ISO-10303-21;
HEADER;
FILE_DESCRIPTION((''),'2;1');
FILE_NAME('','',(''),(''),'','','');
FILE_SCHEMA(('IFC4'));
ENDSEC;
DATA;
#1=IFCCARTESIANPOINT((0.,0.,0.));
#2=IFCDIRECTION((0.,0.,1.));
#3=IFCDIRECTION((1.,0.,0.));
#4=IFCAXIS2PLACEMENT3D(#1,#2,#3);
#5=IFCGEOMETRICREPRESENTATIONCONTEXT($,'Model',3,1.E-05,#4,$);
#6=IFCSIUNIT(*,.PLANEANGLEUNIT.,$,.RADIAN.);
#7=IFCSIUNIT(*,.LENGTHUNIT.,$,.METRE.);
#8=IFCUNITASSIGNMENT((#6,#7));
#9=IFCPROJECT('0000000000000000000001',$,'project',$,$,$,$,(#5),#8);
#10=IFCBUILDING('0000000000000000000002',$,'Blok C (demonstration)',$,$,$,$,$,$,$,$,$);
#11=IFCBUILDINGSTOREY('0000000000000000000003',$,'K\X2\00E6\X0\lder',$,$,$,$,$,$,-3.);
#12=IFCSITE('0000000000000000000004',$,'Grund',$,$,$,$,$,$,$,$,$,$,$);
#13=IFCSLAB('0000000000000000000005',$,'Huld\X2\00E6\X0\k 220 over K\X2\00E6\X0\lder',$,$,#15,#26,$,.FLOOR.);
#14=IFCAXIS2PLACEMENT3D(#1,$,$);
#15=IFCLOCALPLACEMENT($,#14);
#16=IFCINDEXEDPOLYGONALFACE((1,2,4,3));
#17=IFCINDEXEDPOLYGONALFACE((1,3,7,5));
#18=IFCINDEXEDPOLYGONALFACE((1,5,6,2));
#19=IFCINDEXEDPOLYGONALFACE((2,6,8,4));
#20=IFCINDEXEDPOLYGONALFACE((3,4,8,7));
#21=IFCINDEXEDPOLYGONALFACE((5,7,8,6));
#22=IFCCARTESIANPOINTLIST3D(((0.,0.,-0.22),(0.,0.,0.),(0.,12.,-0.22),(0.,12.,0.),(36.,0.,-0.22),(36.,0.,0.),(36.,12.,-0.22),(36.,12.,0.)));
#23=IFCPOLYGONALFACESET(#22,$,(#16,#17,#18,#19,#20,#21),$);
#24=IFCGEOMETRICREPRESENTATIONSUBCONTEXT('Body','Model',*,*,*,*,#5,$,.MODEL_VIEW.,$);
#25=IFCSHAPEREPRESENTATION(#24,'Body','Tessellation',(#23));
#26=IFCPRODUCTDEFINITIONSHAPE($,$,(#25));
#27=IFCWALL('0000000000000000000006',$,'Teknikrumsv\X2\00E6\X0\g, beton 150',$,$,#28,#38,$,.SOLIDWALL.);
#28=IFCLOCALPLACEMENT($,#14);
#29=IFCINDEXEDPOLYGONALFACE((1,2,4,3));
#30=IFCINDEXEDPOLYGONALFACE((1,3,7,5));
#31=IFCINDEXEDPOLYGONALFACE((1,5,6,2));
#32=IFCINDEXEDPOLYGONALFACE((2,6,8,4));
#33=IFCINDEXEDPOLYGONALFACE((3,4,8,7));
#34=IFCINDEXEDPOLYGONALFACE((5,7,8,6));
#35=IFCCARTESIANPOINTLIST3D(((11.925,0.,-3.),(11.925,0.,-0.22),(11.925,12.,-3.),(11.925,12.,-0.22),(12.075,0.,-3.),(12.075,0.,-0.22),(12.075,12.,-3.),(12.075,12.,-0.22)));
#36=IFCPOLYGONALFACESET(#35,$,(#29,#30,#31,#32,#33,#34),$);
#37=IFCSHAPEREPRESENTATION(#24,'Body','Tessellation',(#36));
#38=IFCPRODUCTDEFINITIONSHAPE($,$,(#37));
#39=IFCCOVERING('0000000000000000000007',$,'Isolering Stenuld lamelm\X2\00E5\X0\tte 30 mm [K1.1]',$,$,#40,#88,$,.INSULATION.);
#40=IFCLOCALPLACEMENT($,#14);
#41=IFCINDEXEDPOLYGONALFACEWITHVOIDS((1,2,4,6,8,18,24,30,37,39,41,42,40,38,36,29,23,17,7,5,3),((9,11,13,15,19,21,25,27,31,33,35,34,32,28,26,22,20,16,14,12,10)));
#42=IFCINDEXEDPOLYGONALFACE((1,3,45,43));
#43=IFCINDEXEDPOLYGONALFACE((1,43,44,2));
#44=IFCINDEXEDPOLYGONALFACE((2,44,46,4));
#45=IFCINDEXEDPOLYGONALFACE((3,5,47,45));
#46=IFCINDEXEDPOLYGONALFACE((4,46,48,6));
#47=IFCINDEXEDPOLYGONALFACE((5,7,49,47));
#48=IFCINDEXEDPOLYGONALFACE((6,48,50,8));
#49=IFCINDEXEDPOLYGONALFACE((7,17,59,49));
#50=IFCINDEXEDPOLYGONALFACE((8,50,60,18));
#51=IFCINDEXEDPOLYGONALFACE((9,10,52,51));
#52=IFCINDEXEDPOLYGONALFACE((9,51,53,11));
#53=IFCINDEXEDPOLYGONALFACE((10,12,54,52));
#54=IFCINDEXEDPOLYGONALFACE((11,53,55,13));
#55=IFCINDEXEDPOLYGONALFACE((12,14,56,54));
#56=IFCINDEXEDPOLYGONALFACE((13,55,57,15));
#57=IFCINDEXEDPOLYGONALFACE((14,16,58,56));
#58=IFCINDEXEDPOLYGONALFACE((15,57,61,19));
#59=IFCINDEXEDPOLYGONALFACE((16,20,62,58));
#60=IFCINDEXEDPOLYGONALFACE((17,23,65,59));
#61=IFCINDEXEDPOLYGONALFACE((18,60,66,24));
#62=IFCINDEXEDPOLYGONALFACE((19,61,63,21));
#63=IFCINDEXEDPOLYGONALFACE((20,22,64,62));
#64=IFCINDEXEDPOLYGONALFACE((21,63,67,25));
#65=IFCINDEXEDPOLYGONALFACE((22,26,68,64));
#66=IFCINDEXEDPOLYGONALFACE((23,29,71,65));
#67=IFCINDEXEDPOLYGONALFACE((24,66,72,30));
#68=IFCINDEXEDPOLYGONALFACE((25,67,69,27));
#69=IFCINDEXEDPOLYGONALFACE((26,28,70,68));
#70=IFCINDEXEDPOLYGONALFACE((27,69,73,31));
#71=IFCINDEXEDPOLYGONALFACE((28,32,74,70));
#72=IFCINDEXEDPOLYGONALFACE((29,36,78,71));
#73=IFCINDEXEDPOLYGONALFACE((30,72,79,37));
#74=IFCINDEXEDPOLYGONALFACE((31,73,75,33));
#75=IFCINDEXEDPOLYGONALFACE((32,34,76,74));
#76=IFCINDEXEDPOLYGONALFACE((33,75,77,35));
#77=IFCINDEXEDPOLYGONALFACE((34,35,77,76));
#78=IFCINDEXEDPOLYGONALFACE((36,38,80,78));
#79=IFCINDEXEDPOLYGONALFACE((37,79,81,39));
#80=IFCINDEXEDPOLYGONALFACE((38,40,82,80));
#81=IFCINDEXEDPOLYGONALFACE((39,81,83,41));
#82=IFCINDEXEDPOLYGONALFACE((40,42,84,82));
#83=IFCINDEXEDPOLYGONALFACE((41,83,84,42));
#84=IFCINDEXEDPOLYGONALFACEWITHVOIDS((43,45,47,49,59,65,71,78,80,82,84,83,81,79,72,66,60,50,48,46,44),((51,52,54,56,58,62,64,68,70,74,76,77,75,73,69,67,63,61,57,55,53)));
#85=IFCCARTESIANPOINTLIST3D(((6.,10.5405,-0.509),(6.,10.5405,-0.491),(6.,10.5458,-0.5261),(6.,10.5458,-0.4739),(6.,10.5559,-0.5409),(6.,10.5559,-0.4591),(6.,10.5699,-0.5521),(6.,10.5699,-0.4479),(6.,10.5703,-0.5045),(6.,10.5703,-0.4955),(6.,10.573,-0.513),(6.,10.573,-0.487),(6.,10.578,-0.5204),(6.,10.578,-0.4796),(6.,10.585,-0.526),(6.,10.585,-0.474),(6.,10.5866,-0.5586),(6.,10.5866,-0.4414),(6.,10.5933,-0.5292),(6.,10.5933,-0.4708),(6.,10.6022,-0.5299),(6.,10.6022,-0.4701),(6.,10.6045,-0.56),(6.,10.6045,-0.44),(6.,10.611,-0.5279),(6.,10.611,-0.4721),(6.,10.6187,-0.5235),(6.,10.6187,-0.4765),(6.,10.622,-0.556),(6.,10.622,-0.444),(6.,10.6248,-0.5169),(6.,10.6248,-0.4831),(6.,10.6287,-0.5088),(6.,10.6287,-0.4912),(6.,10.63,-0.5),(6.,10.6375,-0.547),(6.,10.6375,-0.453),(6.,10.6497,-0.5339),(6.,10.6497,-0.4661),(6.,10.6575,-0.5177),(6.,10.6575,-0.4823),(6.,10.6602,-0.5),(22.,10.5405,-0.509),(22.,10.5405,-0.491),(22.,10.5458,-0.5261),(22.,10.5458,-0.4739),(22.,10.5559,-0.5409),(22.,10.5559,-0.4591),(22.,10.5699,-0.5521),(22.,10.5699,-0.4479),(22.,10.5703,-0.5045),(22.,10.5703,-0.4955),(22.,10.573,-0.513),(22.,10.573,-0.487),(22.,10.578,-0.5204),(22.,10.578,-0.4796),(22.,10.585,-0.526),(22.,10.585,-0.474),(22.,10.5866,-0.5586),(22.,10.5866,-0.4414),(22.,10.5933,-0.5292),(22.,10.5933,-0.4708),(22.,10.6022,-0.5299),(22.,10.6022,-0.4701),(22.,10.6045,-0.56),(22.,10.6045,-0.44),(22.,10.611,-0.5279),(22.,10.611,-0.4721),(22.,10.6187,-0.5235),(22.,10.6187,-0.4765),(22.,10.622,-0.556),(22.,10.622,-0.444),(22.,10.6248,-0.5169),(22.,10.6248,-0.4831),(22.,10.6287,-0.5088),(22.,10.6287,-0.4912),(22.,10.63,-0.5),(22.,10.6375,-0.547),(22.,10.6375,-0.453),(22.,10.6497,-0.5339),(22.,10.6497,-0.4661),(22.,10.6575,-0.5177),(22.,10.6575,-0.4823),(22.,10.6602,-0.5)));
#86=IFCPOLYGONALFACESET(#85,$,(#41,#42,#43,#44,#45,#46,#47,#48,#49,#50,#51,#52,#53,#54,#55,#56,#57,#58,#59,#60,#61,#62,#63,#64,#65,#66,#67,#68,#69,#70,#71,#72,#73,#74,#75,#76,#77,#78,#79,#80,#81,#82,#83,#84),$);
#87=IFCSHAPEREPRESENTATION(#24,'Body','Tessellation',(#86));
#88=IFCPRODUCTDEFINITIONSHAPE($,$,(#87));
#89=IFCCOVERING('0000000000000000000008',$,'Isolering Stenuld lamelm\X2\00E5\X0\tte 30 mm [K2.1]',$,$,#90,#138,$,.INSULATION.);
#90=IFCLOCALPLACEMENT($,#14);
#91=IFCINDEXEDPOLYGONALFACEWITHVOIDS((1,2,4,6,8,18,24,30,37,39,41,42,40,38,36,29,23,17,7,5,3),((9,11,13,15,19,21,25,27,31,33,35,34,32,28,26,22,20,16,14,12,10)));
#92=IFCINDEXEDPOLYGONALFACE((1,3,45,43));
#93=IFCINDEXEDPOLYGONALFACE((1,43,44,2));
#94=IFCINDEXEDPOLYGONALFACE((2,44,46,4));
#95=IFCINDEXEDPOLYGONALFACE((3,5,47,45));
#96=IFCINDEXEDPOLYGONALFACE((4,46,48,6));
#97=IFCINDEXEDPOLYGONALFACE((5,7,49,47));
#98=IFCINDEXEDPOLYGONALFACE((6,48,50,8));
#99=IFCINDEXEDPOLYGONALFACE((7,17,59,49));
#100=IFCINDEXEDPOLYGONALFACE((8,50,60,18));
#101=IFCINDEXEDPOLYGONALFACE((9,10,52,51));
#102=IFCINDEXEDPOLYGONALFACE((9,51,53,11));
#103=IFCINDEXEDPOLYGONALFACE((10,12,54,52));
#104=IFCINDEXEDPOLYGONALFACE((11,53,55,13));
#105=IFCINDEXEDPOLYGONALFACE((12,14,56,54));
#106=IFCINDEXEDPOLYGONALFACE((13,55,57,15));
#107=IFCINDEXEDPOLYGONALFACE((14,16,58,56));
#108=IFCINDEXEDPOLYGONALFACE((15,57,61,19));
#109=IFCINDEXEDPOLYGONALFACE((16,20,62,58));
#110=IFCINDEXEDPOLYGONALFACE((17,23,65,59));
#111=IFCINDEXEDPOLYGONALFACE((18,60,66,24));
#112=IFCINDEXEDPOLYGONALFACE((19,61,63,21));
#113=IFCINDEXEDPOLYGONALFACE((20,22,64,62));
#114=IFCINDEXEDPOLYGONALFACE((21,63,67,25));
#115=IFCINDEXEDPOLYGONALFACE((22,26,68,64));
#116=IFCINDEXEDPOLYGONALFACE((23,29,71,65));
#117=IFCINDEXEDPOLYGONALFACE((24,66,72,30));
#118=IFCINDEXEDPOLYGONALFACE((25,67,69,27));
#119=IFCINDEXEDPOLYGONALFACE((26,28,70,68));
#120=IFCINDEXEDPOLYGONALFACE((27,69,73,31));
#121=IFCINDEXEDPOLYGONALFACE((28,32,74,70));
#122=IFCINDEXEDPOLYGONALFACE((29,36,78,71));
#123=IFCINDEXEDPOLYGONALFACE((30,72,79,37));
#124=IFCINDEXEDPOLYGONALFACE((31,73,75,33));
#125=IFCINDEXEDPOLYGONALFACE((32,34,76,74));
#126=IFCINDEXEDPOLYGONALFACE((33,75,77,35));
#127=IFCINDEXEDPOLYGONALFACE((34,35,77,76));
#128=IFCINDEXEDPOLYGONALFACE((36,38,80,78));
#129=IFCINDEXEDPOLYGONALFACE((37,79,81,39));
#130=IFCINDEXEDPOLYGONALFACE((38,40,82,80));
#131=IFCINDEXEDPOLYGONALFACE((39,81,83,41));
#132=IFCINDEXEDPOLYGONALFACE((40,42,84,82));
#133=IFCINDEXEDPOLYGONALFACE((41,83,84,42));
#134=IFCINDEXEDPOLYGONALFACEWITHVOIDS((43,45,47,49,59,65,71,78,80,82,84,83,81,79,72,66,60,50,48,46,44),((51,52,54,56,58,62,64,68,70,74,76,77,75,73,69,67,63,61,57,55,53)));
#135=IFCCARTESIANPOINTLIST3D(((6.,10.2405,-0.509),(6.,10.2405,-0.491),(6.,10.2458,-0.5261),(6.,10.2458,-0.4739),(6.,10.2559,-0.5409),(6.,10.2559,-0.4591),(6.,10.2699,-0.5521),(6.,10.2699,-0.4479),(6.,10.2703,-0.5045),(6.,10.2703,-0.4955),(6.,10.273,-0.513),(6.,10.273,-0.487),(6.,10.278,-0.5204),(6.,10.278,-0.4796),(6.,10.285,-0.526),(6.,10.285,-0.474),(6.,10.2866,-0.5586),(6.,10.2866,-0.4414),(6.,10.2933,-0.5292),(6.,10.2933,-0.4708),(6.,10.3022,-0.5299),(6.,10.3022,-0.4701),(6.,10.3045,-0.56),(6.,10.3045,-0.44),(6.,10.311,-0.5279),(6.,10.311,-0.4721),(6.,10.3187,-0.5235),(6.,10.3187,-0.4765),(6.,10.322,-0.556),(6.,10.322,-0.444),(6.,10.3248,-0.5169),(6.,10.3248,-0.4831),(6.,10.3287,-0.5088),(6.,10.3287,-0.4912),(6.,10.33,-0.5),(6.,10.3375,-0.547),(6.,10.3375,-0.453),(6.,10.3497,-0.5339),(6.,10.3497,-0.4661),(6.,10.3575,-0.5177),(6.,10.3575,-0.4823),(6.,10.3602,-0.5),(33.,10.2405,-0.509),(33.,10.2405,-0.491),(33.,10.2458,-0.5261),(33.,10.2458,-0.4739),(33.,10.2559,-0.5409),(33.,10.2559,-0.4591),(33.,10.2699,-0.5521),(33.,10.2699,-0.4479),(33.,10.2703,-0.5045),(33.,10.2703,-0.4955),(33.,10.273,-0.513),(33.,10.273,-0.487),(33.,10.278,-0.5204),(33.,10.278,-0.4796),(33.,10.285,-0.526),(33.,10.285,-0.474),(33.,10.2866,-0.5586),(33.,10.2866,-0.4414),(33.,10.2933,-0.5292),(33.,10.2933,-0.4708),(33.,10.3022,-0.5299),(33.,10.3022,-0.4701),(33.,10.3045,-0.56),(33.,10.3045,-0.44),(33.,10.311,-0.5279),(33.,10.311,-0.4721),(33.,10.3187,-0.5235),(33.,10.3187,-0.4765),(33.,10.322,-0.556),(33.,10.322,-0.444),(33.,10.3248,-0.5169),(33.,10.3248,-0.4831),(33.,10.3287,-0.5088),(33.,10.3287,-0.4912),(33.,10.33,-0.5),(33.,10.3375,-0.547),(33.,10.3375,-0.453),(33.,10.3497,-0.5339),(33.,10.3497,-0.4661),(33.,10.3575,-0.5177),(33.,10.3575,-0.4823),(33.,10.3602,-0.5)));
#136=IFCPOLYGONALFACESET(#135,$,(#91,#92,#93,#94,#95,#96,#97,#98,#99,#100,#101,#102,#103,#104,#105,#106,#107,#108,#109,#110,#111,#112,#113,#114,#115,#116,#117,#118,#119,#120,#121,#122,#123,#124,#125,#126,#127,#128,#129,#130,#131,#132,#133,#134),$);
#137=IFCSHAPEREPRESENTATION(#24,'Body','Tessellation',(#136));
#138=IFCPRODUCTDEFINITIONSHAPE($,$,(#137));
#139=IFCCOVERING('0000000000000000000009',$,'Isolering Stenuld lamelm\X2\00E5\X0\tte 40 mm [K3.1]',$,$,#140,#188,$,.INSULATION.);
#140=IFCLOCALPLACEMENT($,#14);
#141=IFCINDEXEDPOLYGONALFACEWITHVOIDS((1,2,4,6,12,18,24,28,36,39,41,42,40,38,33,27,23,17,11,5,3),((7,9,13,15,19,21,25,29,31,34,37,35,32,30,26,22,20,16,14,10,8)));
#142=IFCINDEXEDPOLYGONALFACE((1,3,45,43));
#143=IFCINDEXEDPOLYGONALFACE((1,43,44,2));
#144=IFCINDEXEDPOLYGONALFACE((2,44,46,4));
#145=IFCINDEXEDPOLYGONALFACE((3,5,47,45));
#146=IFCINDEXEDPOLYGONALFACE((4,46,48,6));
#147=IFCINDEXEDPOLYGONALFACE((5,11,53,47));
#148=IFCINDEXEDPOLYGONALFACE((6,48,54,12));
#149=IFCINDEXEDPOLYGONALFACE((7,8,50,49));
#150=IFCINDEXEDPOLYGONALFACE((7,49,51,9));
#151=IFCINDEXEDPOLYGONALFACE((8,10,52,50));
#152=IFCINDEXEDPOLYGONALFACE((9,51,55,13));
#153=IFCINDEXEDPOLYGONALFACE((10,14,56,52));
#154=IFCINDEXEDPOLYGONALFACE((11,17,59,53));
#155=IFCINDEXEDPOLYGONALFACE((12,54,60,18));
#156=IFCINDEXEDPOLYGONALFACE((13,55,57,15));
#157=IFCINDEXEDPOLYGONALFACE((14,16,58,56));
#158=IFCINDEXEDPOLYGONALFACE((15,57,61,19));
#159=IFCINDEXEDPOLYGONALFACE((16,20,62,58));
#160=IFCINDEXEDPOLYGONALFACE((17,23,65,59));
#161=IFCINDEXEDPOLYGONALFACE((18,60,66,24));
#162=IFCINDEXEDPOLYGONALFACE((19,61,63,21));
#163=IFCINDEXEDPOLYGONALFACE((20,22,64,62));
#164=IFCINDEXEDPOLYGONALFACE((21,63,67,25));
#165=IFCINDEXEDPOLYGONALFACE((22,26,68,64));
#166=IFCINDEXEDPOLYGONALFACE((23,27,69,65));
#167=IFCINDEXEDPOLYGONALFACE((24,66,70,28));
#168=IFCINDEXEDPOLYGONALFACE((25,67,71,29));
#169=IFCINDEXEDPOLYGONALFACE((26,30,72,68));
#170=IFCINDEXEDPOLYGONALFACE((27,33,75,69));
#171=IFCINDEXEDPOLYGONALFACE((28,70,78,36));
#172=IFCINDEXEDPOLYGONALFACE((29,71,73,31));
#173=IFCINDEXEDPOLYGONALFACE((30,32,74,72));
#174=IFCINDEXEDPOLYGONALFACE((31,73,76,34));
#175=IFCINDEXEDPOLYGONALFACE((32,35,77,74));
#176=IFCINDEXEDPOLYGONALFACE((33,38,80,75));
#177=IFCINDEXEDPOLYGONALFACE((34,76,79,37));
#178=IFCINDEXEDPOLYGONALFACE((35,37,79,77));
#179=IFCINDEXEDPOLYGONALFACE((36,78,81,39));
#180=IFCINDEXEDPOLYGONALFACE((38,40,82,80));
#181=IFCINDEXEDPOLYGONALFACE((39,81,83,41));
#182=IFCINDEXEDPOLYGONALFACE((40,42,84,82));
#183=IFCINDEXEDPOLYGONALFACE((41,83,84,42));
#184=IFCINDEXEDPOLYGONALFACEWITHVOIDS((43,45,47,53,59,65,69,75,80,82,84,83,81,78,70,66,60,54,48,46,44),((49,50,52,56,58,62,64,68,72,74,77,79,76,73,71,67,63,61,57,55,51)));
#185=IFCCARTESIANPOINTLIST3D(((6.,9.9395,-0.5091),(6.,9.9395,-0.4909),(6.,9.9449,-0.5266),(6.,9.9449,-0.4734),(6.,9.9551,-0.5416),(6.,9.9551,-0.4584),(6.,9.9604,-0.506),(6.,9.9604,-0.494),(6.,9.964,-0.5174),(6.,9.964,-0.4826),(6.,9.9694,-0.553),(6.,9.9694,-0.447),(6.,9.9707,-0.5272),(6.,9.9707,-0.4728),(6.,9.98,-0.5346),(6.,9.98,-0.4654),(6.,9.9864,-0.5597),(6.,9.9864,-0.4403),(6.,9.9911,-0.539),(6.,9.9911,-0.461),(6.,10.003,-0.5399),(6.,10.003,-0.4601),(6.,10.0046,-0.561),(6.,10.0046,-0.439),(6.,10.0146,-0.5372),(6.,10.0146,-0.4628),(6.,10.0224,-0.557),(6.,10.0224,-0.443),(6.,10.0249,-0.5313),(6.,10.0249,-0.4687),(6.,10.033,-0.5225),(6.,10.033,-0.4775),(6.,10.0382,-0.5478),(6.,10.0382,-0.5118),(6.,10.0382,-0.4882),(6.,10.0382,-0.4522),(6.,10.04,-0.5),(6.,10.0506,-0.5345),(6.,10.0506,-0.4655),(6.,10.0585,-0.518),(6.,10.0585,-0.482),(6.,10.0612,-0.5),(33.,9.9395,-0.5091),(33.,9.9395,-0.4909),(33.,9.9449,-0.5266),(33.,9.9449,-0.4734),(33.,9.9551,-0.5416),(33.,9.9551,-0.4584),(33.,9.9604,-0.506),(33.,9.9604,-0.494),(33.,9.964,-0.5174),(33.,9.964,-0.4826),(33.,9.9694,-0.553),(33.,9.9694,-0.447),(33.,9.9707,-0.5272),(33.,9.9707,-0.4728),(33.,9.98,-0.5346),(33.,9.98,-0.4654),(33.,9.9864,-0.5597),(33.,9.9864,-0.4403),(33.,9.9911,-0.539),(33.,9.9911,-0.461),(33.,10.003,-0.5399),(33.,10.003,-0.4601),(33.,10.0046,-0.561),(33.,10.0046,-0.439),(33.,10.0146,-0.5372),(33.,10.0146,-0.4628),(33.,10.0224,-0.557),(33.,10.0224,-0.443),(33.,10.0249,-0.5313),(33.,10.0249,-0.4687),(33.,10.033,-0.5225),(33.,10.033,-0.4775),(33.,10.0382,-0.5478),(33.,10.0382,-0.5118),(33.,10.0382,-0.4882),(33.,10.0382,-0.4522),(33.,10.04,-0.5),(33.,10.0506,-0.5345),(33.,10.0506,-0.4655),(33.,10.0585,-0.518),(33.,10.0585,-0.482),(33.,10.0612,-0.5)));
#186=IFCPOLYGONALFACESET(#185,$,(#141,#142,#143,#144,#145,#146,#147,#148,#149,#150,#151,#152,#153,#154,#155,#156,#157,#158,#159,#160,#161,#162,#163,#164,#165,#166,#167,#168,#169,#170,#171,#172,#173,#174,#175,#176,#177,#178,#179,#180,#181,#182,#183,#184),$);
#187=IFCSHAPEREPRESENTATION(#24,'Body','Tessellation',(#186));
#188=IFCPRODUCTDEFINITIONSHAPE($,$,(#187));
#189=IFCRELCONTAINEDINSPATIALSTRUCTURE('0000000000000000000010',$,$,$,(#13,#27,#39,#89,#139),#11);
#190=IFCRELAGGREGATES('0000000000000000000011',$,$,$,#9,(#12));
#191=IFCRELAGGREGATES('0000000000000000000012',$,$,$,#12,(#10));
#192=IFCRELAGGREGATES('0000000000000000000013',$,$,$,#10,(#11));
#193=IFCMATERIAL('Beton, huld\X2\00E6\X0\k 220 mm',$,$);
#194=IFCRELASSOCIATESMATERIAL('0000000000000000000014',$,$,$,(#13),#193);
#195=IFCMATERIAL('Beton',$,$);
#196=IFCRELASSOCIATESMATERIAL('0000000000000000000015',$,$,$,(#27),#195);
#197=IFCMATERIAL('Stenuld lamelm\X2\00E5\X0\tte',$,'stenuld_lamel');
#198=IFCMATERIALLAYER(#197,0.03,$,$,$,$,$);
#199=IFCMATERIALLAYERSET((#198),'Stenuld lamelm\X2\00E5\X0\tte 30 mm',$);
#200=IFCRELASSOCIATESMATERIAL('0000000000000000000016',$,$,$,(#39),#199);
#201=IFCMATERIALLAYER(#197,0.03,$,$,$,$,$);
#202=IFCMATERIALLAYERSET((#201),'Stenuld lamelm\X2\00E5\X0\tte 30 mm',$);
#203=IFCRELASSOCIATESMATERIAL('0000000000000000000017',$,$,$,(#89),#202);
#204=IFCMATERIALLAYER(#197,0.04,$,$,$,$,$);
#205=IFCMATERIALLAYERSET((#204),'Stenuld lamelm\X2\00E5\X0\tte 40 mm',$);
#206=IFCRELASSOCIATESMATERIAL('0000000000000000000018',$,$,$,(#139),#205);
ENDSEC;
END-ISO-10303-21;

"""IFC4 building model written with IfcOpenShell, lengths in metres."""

from ifc_helpers import new_model, si_unit, frame, origin_with_axes, place, context, subcontext, project, spatial, polyline, hollow_circle, outline, extrude, material, layer, layer_set, element, save


model = new_model("IFC4")

# Units and contexts
model_context = context("Model", 3, precision=1e-05, world=origin_with_axes())
body_context = subcontext(model_context, "Body", "Model", "MODEL_VIEW")
ifc_project = project(units=[si_unit("PLANEANGLEUNIT", "RADIAN"), si_unit("LENGTHUNIT", "METRE")], contexts=[model_context])

# Site, building, storey
site = spatial("IfcSite", under=ifc_project, Name="Grund")
building = spatial("IfcBuilding", under=site, Name="Blok C (demonstration)")
storey = spatial("IfcBuildingStorey", under=building, Name="Kælder", Elevation=-3.0)

# Slab
ifc_material_1 = material(Name="Beton, huldæk 220 mm")
slab_placement = place(None, origin_with_axes())
element("IfcSlab", 1, at=slab_placement, inside=storey, material=ifc_material_1, Name="Huldæk 220 over Kælder", PredefinedType="FLOOR", context=body_context, shape_type="SweptSolid", body=[
    extrude(outline(polyline([(0.0, 0.0), (36.0, 0.0), (36.0, 12.0), (0.0, 12.0), (0.0, 0.0)])), frame((0.0, 0.0, -0.22)), (0.0, 0.0, 1.0), 0.22),
])

# Wall
ifc_material_2 = material(Name="Beton")
wall_placement = place(None, origin_with_axes())
element("IfcWall", 2, at=wall_placement, inside=storey, material=ifc_material_2, Name="Teknikrumsvæg, beton 150", PredefinedType="SOLIDWALL", context=body_context, shape_type="SweptSolid", body=[
    extrude(outline(polyline([(11.925, 0.0), (12.075, 0.0), (12.075, 12.0), (11.925, 12.0), (11.925, 0.0)])), frame((0.0, 0.0, -3.0)), (0.0, 0.0, 1.0), 2.78),
])

# Coverings
ifc_material_3 = material(Name="Stenuld lamelmåtte", Category="stenuld_lamel")
ifc_layer_1 = layer(ifc_material_3, 0.03)
ifc_layer_set_1 = layer_set([ifc_layer_1], Name="Stenuld lamelmåtte 30 mm")
covering_1_placement = place(None, origin_with_axes())
element("IfcCovering", 3, at=covering_1_placement, inside=storey, material=ifc_layer_set_1, Name="Isolering Stenuld lamelmåtte 30 mm [K1.1]", PredefinedType="INSULATION", context=body_context, shape_type="SweptSolid", body=[
    extrude(hollow_circle(Radius=0.0601, WallThickness=0.0301), frame((6.0, 10.6, -0.5), z_axis=(1.0, 0.0, 0.0), x_axis=(0.0, 1.0, 0.0)), (0.0, 0.0, 1.0), 16.0),
])
ifc_layer_2 = layer(ifc_material_3, 0.03)
ifc_layer_set_2 = layer_set([ifc_layer_2], Name="Stenuld lamelmåtte 30 mm")
covering_2_placement = place(None, origin_with_axes())
element("IfcCovering", 4, at=covering_2_placement, inside=storey, material=ifc_layer_set_2, Name="Isolering Stenuld lamelmåtte 30 mm [K2.1]", PredefinedType="INSULATION", context=body_context, shape_type="SweptSolid", body=[
    extrude(hollow_circle(Radius=0.0601, WallThickness=0.0301), frame((6.0, 10.3, -0.5), z_axis=(1.0, 0.0, 0.0), x_axis=(0.0, 1.0, 0.0)), (0.0, 0.0, 1.0), 27.0),
])
ifc_layer_3 = layer(ifc_material_3, 0.04)
ifc_layer_set_3 = layer_set([ifc_layer_3], Name="Stenuld lamelmåtte 40 mm")
covering_3_placement = place(None, origin_with_axes())
element("IfcCovering", 5, at=covering_3_placement, inside=storey, material=ifc_layer_set_3, Name="Isolering Stenuld lamelmåtte 40 mm [K3.1]", PredefinedType="INSULATION", context=body_context, shape_type="SweptSolid", body=[
    extrude(hollow_circle(Radius=0.0612, WallThickness=0.0212), frame((6.0, 10.0, -0.5), z_axis=(1.0, 0.0, 0.0), x_axis=(0.0, 1.0, 0.0)), (0.0, 0.0, 1.0), 27.0),
])

save(model, "model.ifc")
